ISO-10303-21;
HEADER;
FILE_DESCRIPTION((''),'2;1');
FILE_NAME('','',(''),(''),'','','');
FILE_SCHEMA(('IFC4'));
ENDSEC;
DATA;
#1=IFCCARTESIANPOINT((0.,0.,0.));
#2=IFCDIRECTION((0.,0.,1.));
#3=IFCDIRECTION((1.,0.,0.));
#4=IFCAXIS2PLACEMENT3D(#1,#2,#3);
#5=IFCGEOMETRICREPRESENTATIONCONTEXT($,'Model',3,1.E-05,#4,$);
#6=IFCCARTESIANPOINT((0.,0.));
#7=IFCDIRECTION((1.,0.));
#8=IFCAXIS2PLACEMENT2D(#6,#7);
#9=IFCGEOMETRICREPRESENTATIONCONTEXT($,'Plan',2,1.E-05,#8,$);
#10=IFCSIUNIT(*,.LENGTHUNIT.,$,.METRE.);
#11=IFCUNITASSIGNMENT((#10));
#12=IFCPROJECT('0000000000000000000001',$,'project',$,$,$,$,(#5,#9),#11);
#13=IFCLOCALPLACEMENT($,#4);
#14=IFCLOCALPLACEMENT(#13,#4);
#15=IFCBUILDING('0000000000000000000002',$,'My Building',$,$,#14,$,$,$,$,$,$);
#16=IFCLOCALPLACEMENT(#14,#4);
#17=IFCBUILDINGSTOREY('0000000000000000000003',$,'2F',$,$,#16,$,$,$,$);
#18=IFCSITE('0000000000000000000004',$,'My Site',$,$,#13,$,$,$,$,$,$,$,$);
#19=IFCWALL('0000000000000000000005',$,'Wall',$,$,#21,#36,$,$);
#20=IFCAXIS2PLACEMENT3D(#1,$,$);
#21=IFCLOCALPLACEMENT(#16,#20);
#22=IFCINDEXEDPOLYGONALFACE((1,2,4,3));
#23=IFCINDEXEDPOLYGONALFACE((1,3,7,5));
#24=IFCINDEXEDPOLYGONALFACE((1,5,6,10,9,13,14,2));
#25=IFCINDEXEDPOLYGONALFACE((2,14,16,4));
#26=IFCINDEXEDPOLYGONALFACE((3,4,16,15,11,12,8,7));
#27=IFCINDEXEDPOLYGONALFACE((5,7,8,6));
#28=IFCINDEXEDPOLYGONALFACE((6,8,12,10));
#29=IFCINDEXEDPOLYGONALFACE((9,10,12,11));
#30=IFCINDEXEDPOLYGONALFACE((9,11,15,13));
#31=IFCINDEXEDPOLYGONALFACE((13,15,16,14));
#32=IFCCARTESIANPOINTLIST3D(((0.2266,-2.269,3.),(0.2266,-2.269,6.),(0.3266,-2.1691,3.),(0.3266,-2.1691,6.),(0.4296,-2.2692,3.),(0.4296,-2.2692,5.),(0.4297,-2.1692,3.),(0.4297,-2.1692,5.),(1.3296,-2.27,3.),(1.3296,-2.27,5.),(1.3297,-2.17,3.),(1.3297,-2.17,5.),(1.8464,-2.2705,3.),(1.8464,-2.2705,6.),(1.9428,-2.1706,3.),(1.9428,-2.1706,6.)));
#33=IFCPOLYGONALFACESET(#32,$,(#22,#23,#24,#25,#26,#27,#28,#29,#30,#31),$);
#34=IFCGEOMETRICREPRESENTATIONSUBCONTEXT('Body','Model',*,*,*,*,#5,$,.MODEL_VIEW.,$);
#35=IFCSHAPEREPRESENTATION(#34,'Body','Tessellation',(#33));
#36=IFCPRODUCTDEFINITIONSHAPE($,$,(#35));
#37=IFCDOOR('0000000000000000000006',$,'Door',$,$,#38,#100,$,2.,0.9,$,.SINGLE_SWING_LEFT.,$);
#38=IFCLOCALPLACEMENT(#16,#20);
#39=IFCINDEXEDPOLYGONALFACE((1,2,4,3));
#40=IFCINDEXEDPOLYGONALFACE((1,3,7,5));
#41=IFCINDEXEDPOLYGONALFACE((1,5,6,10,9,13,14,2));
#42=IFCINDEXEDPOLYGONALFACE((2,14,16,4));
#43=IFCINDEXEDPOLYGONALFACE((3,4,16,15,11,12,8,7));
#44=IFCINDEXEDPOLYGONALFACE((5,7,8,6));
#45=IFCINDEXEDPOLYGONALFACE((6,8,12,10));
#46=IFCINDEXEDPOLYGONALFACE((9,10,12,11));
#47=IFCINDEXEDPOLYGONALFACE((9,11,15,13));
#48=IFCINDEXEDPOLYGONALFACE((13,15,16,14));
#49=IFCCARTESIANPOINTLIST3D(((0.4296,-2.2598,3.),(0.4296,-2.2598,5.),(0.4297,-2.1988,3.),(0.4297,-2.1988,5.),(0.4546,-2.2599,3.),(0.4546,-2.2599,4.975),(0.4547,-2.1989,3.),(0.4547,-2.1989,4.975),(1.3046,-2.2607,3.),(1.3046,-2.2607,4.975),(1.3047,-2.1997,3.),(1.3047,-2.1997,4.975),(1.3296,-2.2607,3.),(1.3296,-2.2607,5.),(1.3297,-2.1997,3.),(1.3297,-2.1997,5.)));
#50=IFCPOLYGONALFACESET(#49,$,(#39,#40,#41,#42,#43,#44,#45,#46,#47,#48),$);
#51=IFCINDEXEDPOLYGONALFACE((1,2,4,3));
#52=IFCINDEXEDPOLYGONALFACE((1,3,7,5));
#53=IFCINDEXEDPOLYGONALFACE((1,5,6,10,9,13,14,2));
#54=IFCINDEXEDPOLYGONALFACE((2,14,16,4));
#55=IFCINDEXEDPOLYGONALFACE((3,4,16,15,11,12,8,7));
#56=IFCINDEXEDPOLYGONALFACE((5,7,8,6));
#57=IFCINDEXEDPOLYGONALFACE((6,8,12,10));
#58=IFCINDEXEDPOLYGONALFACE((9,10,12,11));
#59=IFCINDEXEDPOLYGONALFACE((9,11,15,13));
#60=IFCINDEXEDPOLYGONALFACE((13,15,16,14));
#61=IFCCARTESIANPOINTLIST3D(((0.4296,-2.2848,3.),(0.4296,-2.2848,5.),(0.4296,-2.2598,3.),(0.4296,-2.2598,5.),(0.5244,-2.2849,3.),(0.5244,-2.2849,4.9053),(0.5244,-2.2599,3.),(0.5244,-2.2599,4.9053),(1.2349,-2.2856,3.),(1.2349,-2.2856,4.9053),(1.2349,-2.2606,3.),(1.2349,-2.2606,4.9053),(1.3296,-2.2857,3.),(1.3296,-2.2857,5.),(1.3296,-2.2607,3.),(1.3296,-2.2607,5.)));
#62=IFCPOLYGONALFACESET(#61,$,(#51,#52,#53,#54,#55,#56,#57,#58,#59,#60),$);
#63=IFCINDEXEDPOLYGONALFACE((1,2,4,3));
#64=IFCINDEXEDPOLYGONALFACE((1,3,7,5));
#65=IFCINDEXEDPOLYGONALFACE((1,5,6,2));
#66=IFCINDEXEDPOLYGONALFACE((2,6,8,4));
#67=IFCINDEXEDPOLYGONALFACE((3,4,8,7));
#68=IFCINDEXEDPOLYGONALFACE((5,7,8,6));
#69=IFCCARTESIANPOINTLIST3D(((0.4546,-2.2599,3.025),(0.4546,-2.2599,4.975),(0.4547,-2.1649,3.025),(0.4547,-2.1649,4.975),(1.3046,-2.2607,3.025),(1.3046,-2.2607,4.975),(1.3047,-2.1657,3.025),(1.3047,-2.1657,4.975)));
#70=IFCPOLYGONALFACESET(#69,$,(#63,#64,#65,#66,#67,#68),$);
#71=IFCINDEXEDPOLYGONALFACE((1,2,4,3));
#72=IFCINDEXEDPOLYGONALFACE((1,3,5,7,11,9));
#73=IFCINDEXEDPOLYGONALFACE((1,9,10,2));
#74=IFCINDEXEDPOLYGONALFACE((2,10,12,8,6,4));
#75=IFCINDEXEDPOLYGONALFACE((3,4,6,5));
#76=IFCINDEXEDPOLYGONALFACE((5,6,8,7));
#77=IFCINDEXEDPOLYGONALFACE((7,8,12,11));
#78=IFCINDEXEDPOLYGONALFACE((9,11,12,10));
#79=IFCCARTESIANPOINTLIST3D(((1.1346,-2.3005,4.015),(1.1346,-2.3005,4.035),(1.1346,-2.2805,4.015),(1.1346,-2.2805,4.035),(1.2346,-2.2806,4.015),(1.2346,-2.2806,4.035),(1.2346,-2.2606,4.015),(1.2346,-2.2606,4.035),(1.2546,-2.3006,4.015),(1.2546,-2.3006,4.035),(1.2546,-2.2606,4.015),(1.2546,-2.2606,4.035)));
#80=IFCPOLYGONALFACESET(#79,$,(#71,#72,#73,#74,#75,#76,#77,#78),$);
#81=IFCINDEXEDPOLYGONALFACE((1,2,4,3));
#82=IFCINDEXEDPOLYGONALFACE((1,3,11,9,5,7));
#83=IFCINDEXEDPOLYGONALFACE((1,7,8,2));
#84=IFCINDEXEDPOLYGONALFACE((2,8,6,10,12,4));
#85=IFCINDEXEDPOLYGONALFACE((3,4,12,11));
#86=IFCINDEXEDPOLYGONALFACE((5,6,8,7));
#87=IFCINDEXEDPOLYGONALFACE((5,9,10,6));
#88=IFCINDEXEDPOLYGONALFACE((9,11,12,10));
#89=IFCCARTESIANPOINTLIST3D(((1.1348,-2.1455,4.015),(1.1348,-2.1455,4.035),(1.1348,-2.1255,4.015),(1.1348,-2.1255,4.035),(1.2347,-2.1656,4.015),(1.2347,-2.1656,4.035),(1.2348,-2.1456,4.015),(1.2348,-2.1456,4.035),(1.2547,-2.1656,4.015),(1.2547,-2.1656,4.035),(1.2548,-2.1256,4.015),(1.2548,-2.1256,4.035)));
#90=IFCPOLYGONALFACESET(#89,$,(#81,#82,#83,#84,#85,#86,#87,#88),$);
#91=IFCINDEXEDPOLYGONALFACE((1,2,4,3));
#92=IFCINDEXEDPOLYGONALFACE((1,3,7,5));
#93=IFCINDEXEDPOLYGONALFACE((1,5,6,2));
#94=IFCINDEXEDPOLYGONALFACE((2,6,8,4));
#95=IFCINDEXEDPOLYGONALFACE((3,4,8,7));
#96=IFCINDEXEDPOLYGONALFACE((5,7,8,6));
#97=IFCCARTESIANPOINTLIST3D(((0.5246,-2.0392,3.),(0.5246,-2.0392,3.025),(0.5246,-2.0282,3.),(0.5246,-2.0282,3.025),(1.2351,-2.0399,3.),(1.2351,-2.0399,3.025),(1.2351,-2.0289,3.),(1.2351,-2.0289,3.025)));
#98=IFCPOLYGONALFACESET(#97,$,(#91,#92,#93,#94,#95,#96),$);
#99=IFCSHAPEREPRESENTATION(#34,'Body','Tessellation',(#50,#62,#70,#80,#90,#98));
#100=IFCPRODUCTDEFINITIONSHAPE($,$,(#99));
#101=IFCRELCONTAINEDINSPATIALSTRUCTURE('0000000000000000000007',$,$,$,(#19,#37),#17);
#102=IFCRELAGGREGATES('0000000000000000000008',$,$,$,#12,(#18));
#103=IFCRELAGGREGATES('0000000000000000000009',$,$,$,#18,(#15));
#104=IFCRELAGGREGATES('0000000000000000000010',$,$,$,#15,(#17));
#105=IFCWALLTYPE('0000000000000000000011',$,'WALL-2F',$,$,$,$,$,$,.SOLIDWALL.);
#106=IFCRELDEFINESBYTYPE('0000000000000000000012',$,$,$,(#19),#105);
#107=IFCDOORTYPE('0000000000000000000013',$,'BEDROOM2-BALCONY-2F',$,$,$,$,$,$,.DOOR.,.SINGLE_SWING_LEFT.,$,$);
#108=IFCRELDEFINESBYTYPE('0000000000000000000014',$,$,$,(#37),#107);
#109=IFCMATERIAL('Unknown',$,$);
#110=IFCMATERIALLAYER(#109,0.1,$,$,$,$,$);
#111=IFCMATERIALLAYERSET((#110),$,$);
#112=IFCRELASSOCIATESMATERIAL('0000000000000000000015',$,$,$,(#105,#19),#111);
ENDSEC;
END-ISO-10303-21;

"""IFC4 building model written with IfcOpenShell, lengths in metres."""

from ifc_helpers import new_model, entity, si_unit, frame, origin_with_axes, origin_2d_with_axis, place, context, subcontext, project, spatial, line, indexed_curve, outline, extrude, shape, source, transform, mapped, material, layer, layer_set, layer_usage, type_object, type_shapes, element, fill, save


model = new_model("IFC4")

# Units and contexts
model_context = context("Model", 3, precision=1e-05, world=origin_with_axes())
plan_context = context("Plan", 2, precision=1e-05, world=origin_2d_with_axis())
body_context_1 = subcontext(model_context, "Body", "Model", "MODEL_VIEW")
body_context_2 = subcontext(plan_context, "Body", "Plan", "PLAN_VIEW")
ifc_project = project(units=[si_unit("LENGTHUNIT", "METRE")], contexts=[model_context, plan_context])

# Site, building, storey
site_placement = place(None, origin_with_axes())
site = spatial("IfcSite", under=ifc_project, at=site_placement, Name="My Site")
building_placement = place(site_placement, origin_with_axes())
building = spatial("IfcBuilding", under=site, at=building_placement, Name="My Building")
storey_placement = place(building_placement, origin_with_axes())
storey = spatial("IfcBuildingStorey", under=building, at=storey_placement, Name="2F")

# Shared definitions
ifc_material = material(Name="Unknown")

# Shared definitions
ifc_layer_1 = layer(ifc_material, 0.1)
ifc_layer_set_1 = layer_set([ifc_layer_1])
wall_type_1 = type_object("IfcWallType", Name="WALL-2F", PredefinedType="SOLIDWALL", material=ifc_layer_set_1)

# Wall, opening, door
ifc_layer_usage_1 = layer_usage(ifc_layer_set_1, "AXIS2", "POSITIVE", 0.0)
wall_1_placement = place(storey_placement, frame((1.9428, -2.1706, 3.0), z_axis=(0.0, 0.0, 1.0), x_axis=(-1.0, 0.000946, 0.0)))
wall_1 = element("IfcWall", 1, at=wall_1_placement, inside=storey, type_object=wall_type_1, material=ifc_layer_usage_1, Name="Wall", context=body_context_1, shape_type="SweptSolid", body=[
    extrude(outline(indexed_curve([(0.0, 0.0), (0.0963, 0.1), (1.7161, 0.1), (1.6162, 0.0)], segments=[line(1, 2, 3, 4, 1)])), origin_with_axes(), (0.0, 0.0, 1.0), 3.0),
])
shared_shape_1 = source(origin_with_axes(), body_context_1, "Body", "SweptSolid", [
    extrude(outline(indexed_curve([(0.0, 0.0), (0.9, 0.0), (0.9, 2.0), (0.0, 2.0)], segments=[line(1, 2, 3, 4, 1)])), frame((0.0, -0.6, 0.0), z_axis=(0.0, -1.0, 0.0), x_axis=(1.0, 0.0, 0.0)), (0.0, 0.0, -1.0), 1.2),
])
opening_1_placement = place(wall_1_placement, frame((1.513, 0.1, 0.0), z_axis=(0.0, 0.0, 1.0), x_axis=(-1.0, 0.0, 0.0)))
opening_1 = element("IfcOpeningElement", 2, at=opening_1_placement, cuts=wall_1, PredefinedType="OPENING", context=body_context_1, shape_type="MappedRepresentation", body=[
    mapped(shared_shape_1, transform((0.0, 0.0, 0.0), x_axis=(1.0, 0.0, 0.0), y_axis=(0.0, 1.0, 0.0), z_axis=(0.0, 0.0, 1.0), scale=1.0)),
])
door_type_1 = type_object("IfcDoorType", Name="BEDROOM2-BALCONY-2F", OperationType="SINGLE_SWING_LEFT", PredefinedType="DOOR")
shared_shape_2 = source(origin_with_axes(), body_context_1, "Body", "SweptSolid", [
    extrude(outline(indexed_curve([(0.0, 0.0), (0.0, 2.0), (0.9, 2.0), (0.9, 0.0), (0.875, 0.0), (0.875, 1.975), (0.025, 1.975), (0.025, 0.0)], segments=[line(1, 2, 3, 4, 5, 6, 7, 8, 1)])), frame((0.0, 0.0093, 0.0), z_axis=(0.0, -1.0, 0.0), x_axis=(1.0, 0.0, 0.0)), (0.0, 0.0, -1.0), 0.061),
    extrude(outline(indexed_curve([(0.0, 0.0), (0.0, 2.0), (0.9, 2.0), (0.9, 0.0), (0.8053, 0.0), (0.8053, 1.9053), (0.0947, 1.9053), (0.0947, 0.0)], segments=[line(1, 2, 3, 4, 5, 6, 7, 8, 1)])), frame((0.0, -0.0157, 0.0), z_axis=(0.0, -1.0, 0.0), x_axis=(1.0, 0.0, 0.0)), (0.0, 0.0, -1.0), 0.025),
    extrude(outline(indexed_curve([(0.0, 0.0), (0.85, 0.0), (0.85, 0.095), (0.0, 0.095)], segments=[line(1, 2, 3, 4, 1)])), frame((0.025, 0.0093, 0.025), z_axis=(0.0, 0.0, 1.0), x_axis=(1.0, 0.0, 0.0)), (0.0, 0.0, 1.0), 1.95),
    extrude(outline(indexed_curve([(0.0, 0.0), (0.0, -0.04), (-0.12, -0.04), (-0.12, -0.02), (-0.02, -0.02), (-0.02, 0.0)], segments=[line(1, 2, 3, 4, 5, 6, 1)])), frame((0.825, 0.0093, 1.015), z_axis=(0.0, 0.0, 1.0), x_axis=(1.0, 0.0, 0.0)), (0.0, 0.0, 1.0), 0.02),
    extrude(outline(indexed_curve([(0.0, 0.0), (0.0, 0.04), (-0.12, 0.04), (-0.12, 0.02), (-0.02, 0.02), (-0.02, 0.0)], segments=[line(1, 2, 3, 4, 5, 6, 1)])), frame((0.825, 0.1043, 1.015), z_axis=(0.0, 0.0, 1.0), x_axis=(1.0, 0.0, 0.0)), (0.0, 0.0, 1.0), 0.02),
    extrude(outline(indexed_curve([(0.0, 0.0), (0.7105, 0.0), (0.7105, 0.011), (0.0, 0.011)], segments=[line(1, 2, 3, 4, 1)])), frame((0.0947, 0.23, 0.0), z_axis=(0.0, 0.0, 1.0), x_axis=(1.0, 0.0, 0.0)), (0.0, 0.0, 1.0), 0.025),
])
shared_shape_3 = source(origin_with_axes(), body_context_2, "Body", "Curve2D", [
    entity("IfcIndexedPolyCurve", entity("IfcCartesianPointList2D", [[0.0, -0.0157], [0.0, 0.0703], [0.025, 0.0703], [0.025, 0.0093], [0.0947, 0.0093], [0.0947, -0.0157]]), [entity("IfcLineIndex", [1, 2, 3, 4, 5, 6, 1])]),
    entity("IfcIndexedPolyCurve", entity("IfcCartesianPointList2D", [[0.9, -0.0157], [0.9, 0.0703], [0.875, 0.0703], [0.875, 0.0093], [0.8053, 0.0093], [0.8053, -0.0157]]), [entity("IfcLineIndex", [1, 2, 3, 4, 5, 6, 1])]),
    entity("IfcTrimmedCurve", entity("IfcEllipse", entity("IfcAxis2Placement2D", entity("IfcCartesianPoint", [0.12, 0.0703]), entity("IfcDirection", [1.0, 0.0])), 0.755, 0.85), [entity("IfcCartesianPoint", [0.875, 0.0703])], [entity("IfcCartesianPoint", [0.12, 0.9203])], True, "CARTESIAN"),
    entity("IfcIndexedPolyCurve", entity("IfcCartesianPointList2D", [[0.025, 0.0703], [0.12, 0.0703], [0.12, 0.9203], [0.025, 0.9203]]), [entity("IfcLineIndex", [1, 2, 3, 4, 1])]),
])
type_shapes(door_type_1, [shared_shape_2, shared_shape_3])
door_1_placement = place(opening_1_placement, frame((0.0, 0.0, 0.0), z_axis=(0.0, 0.0, 1.0), x_axis=(1.0, 0.0, 0.0)))
door_1 = element("IfcDoor", 3, at=door_1_placement, inside=storey, type_object=door_type_1, Name="Door", OperationType="SINGLE_SWING_LEFT", OverallHeight=2.0, OverallWidth=0.9, shapes=[
    shape(body_context_1, "Body", "MappedRepresentation", [mapped(shared_shape_2, transform((0.0, 0.0, 0.0), x_axis=(1.0, 0.0, 0.0), y_axis=(0.0, 1.0, 0.0), z_axis=(0.0, 0.0, 1.0), scale=1.0))]),
    shape(body_context_2, "Body", "MappedRepresentation", [mapped(shared_shape_3, transform((0.0, 0.0, 0.0), x_axis=(1.0, 0.0, 0.0), y_axis=(0.0, 1.0, 0.0), z_axis=(0.0, 0.0, 1.0), scale=1.0))]),
])
fill(opening_1, door_1)

save(model, "model.ifc")
